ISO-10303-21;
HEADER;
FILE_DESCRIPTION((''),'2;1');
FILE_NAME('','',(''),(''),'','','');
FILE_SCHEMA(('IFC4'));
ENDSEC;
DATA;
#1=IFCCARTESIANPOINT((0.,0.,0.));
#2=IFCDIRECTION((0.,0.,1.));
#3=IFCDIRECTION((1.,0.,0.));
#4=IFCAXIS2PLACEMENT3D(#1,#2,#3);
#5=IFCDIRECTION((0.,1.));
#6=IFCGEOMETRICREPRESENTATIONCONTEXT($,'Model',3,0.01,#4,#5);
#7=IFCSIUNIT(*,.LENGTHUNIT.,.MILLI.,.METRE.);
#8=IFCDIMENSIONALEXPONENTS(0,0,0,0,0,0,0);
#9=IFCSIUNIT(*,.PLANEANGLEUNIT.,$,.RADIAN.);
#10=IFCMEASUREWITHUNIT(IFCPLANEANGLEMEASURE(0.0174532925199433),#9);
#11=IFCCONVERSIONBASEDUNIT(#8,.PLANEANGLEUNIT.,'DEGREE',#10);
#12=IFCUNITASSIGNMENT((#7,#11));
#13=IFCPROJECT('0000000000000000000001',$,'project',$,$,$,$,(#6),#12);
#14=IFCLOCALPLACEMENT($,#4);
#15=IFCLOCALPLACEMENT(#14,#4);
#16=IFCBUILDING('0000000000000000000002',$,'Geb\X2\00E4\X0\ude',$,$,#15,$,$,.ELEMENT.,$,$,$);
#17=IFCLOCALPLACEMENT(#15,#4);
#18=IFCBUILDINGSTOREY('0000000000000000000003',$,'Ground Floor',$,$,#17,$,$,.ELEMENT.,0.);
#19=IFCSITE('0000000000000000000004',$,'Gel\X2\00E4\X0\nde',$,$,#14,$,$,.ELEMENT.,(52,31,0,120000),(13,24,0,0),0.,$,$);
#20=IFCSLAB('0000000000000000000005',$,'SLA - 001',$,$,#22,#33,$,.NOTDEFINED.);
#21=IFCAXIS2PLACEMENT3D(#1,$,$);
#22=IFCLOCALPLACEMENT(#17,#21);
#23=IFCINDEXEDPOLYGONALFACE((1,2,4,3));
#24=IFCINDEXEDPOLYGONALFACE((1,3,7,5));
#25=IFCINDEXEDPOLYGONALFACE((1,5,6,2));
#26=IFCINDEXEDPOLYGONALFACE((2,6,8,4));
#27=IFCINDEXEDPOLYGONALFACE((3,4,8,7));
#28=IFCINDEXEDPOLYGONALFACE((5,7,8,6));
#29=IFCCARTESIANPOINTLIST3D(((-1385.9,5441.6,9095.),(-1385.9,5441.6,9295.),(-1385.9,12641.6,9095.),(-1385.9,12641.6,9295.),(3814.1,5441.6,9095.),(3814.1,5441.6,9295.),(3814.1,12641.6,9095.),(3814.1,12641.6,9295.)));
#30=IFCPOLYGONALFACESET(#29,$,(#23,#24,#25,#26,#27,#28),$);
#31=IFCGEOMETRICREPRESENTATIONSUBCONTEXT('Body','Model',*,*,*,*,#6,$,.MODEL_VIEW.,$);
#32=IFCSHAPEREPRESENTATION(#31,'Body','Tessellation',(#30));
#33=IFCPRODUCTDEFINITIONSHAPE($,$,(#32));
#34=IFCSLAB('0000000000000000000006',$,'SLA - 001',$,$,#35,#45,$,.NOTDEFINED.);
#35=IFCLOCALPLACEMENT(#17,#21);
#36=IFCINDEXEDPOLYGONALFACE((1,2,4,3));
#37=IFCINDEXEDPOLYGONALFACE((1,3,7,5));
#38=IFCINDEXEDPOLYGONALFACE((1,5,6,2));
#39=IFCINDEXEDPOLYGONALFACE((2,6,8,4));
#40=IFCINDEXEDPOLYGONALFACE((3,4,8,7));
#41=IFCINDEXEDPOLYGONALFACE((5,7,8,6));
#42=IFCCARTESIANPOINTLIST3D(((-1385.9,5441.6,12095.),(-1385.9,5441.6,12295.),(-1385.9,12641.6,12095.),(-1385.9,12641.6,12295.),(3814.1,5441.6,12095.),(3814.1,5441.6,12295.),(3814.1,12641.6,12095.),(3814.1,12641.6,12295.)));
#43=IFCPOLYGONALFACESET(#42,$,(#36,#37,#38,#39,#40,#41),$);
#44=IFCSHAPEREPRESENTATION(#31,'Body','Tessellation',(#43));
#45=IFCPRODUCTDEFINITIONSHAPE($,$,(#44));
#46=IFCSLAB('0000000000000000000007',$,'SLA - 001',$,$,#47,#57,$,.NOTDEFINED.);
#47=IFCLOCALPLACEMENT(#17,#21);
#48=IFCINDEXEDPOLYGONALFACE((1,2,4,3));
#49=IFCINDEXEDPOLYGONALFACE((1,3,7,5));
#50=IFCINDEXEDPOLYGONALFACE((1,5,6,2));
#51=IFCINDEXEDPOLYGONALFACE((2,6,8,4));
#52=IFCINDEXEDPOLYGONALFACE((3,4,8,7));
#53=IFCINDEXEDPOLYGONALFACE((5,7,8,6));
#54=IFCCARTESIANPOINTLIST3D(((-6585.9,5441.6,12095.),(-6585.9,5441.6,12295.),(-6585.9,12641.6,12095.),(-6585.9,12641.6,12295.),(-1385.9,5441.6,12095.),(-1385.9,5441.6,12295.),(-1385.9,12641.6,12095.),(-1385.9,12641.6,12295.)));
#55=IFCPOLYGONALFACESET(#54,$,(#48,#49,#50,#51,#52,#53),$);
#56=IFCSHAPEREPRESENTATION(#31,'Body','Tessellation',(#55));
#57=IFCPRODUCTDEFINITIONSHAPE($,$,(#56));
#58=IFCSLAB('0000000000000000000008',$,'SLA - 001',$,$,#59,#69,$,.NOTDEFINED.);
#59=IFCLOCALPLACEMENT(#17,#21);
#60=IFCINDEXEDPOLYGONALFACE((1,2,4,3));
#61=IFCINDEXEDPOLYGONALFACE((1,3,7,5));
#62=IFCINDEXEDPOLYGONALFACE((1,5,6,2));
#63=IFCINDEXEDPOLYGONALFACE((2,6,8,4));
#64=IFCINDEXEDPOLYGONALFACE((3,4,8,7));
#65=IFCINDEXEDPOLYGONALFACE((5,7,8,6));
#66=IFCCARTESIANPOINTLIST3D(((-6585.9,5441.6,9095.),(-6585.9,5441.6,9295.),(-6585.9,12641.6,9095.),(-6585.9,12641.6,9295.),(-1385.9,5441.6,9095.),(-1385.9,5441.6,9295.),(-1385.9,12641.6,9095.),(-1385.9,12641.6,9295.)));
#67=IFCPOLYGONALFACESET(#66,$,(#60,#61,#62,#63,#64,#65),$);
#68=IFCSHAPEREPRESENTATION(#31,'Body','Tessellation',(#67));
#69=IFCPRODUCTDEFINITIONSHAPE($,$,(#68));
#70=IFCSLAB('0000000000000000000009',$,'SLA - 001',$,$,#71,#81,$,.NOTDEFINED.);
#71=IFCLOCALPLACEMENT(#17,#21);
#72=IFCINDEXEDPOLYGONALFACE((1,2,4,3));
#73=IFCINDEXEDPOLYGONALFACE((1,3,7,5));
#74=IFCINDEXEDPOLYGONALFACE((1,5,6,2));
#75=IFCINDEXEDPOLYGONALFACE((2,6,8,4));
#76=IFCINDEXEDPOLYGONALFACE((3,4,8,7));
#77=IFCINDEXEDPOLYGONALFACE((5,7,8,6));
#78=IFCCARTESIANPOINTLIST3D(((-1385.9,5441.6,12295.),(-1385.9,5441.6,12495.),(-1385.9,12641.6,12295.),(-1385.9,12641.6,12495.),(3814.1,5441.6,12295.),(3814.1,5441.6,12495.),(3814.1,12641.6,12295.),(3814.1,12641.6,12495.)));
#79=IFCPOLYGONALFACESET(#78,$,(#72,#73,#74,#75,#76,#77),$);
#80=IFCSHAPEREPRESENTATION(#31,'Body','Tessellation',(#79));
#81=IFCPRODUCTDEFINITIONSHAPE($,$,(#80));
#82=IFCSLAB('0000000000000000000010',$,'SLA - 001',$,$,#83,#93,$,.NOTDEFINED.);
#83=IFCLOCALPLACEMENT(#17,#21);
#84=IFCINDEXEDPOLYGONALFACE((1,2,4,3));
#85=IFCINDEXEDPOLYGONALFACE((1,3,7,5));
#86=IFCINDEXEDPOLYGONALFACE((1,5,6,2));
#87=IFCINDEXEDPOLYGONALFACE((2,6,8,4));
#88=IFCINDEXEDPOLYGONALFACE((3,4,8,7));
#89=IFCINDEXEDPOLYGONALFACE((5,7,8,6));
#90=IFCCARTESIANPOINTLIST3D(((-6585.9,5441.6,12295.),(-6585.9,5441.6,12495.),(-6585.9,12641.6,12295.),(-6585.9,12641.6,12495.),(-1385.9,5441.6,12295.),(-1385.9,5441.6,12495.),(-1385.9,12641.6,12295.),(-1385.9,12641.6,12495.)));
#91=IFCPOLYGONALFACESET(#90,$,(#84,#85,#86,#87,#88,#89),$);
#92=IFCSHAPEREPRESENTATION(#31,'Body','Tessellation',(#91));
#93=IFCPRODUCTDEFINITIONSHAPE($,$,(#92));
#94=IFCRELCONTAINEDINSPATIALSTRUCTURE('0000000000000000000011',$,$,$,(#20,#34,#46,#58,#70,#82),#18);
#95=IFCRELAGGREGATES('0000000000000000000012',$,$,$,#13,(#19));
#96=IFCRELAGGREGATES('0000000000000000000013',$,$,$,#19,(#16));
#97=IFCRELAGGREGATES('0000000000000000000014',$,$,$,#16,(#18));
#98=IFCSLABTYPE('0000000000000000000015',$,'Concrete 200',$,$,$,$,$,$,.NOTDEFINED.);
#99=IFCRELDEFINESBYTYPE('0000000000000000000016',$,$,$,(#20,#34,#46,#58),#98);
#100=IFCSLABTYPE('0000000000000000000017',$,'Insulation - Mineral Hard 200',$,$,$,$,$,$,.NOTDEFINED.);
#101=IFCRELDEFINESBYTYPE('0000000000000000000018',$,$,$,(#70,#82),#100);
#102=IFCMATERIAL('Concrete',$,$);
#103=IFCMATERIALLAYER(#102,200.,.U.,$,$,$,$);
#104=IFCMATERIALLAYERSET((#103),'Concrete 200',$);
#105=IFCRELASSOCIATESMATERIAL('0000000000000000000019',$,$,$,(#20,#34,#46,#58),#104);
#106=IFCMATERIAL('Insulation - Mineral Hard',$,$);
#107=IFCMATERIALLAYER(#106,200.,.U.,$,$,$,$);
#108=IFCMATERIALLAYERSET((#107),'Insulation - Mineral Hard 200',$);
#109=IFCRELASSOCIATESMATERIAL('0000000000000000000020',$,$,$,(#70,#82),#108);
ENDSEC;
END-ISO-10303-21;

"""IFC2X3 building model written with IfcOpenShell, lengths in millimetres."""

from ifc_helpers import new_model, entity, si_unit, converted_unit, direction, frame, origin_with_axes, place, context, subcontext, project, spatial, polyline, outline, extrude, material, layer, layer_set, layer_usage, type_object, element, save


model = new_model("IFC2X3")

# Units and contexts
model_context = context("Model", 3, precision=0.01, world=origin_with_axes(), true_north=direction((0.0, 1.0)))
body_context = subcontext(model_context, "Body", "Model", "MODEL_VIEW")
ifc_project = project(units=[si_unit("LENGTHUNIT", "METRE", prefix="MILLI"), converted_unit("PLANEANGLEUNIT", "DEGREE", entity("IfcPlaneAngleMeasure", 0.0174532925199433), si_unit("PLANEANGLEUNIT", "RADIAN"), dimensions=[0, 0, 0, 0, 0, 0, 0])], contexts=[model_context])

# Site, building, storey
site_placement = place(None, origin_with_axes())
site = spatial("IfcSite", under=ifc_project, at=site_placement, Name="Gelände", CompositionType="ELEMENT", RefLatitude=(52, 31, 0, 120000), RefLongitude=(13, 24, 0, 0), RefElevation=0.0)
building_placement = place(site_placement, origin_with_axes())
building = spatial("IfcBuilding", under=site, at=building_placement, Name="Gebäude", CompositionType="ELEMENT")
storey_placement = place(building_placement, origin_with_axes())
storey = spatial("IfcBuildingStorey", under=building, at=storey_placement, Name="Ground Floor", CompositionType="ELEMENT", Elevation=0.0)

# Slabs
ifc_material_1 = material(Name="Concrete")
ifc_layer_1 = layer(ifc_material_1, 200.0, ventilated="UNKNOWN")
ifc_layer_set_1 = layer_set([ifc_layer_1], Name="Concrete 200")
ifc_layer_usage_1 = layer_usage(ifc_layer_set_1, "AXIS3", "NEGATIVE", 200.0)
slab_type_1 = type_object("IfcSlabType", Name="Concrete 200", PredefinedType="NOTDEFINED")
slab_1_placement = place(storey_placement, frame((-1385.9, 5441.6, 9295.0), z_axis=(0.0, 0.0, 1.0), x_axis=(1.0, 0.0, 0.0)))
element("IfcSlab", 1, at=slab_1_placement, inside=storey, type_object=slab_type_1, material=ifc_layer_usage_1, Name="SLA - 001", PredefinedType="NOTDEFINED", context=body_context, shape_type="SweptSolid", body=[
    extrude(outline(polyline([(0.0, 0.0), (5200.0, 0.0), (5200.0, 7200.0), (0.0, 7200.0), (0.0, 0.0)])), frame((0.0, 0.0, -200.0), z_axis=(0.0, 0.0, 1.0), x_axis=(1.0, 0.0, 0.0)), (0.0, 0.0, 1.0), 200.0),
])
ifc_layer_usage_2 = layer_usage(ifc_layer_set_1, "AXIS3", "NEGATIVE", 200.0)
slab_2_placement = place(storey_placement, frame((-1385.9, 5441.6, 12295.0), z_axis=(0.0, 0.0, 1.0), x_axis=(1.0, 0.0, 0.0)))
element("IfcSlab", 2, at=slab_2_placement, inside=storey, type_object=slab_type_1, material=ifc_layer_usage_2, Name="SLA - 001", PredefinedType="NOTDEFINED", context=body_context, shape_type="SweptSolid", body=[
    extrude(outline(polyline([(0.0, 0.0), (5200.0, 0.0), (5200.0, 7200.0), (0.0, 7200.0), (0.0, 0.0)])), frame((0.0, 0.0, -200.0), z_axis=(0.0, 0.0, 1.0), x_axis=(1.0, 0.0, 0.0)), (0.0, 0.0, 1.0), 200.0),
])
ifc_layer_usage_3 = layer_usage(ifc_layer_set_1, "AXIS3", "NEGATIVE", 200.0)
slab_3_placement = place(storey_placement, frame((-6585.9, 5441.6, 12295.0), z_axis=(0.0, 0.0, 1.0), x_axis=(1.0, 0.0, 0.0)))
element("IfcSlab", 3, at=slab_3_placement, inside=storey, type_object=slab_type_1, material=ifc_layer_usage_3, Name="SLA - 001", PredefinedType="NOTDEFINED", context=body_context, shape_type="SweptSolid", body=[
    extrude(outline(polyline([(0.0, 0.0), (5200.0, 0.0), (5200.0, 7200.0), (0.0, 7200.0), (0.0, 0.0)])), frame((0.0, 0.0, -200.0), z_axis=(0.0, 0.0, 1.0), x_axis=(1.0, 0.0, 0.0)), (0.0, 0.0, 1.0), 200.0),
])
ifc_layer_usage_4 = layer_usage(ifc_layer_set_1, "AXIS3", "NEGATIVE", 200.0)
slab_4_placement = place(storey_placement, frame((-6585.9, 5441.6, 9295.0), z_axis=(0.0, 0.0, 1.0), x_axis=(1.0, 0.0, 0.0)))
element("IfcSlab", 4, at=slab_4_placement, inside=storey, type_object=slab_type_1, material=ifc_layer_usage_4, Name="SLA - 001", PredefinedType="NOTDEFINED", context=body_context, shape_type="SweptSolid", body=[
    extrude(outline(polyline([(0.0, 0.0), (5200.0, 0.0), (5200.0, 7200.0), (0.0, 7200.0), (0.0, 0.0)])), frame((0.0, 0.0, -200.0), z_axis=(0.0, 0.0, 1.0), x_axis=(1.0, 0.0, 0.0)), (0.0, 0.0, 1.0), 200.0),
])
ifc_material_2 = material(Name="Insulation - Mineral Hard")
ifc_layer_2 = layer(ifc_material_2, 200.0, ventilated="UNKNOWN")
ifc_layer_set_2 = layer_set([ifc_layer_2], Name="Insulation - Mineral Hard 200")
ifc_layer_usage_5 = layer_usage(ifc_layer_set_2, "AXIS3", "NEGATIVE", 200.0)
slab_type_2 = type_object("IfcSlabType", Name="Insulation - Mineral Hard 200", PredefinedType="NOTDEFINED")
slab_5_placement = place(storey_placement, frame((-1385.9, 5441.6, 12495.0), z_axis=(0.0, 0.0, 1.0), x_axis=(1.0, 0.0, 0.0)))
element("IfcSlab", 5, at=slab_5_placement, inside=storey, type_object=slab_type_2, material=ifc_layer_usage_5, Name="SLA - 001", PredefinedType="NOTDEFINED", context=body_context, shape_type="SweptSolid", body=[
    extrude(outline(polyline([(0.0, 0.0), (5200.0, 0.0), (5200.0, 7200.0), (0.0, 7200.0), (0.0, 0.0)])), frame((0.0, 0.0, -200.0), z_axis=(0.0, 0.0, 1.0), x_axis=(1.0, 0.0, 0.0)), (0.0, 0.0, 1.0), 200.0),
])
ifc_layer_usage_6 = layer_usage(ifc_layer_set_2, "AXIS3", "NEGATIVE", 200.0)
slab_6_placement = place(storey_placement, frame((-6585.9, 5441.6, 12495.0), z_axis=(0.0, 0.0, 1.0), x_axis=(1.0, 0.0, 0.0)))
element("IfcSlab", 6, at=slab_6_placement, inside=storey, type_object=slab_type_2, material=ifc_layer_usage_6, Name="SLA - 001", PredefinedType="NOTDEFINED", context=body_context, shape_type="SweptSolid", body=[
    extrude(outline(polyline([(0.0, 0.0), (5200.0, 0.0), (5200.0, 7200.0), (0.0, 7200.0), (0.0, 0.0)])), frame((0.0, 0.0, -200.0), z_axis=(0.0, 0.0, 1.0), x_axis=(1.0, 0.0, 0.0)), (0.0, 0.0, 1.0), 200.0),
])

save(model, "model.ifc")
